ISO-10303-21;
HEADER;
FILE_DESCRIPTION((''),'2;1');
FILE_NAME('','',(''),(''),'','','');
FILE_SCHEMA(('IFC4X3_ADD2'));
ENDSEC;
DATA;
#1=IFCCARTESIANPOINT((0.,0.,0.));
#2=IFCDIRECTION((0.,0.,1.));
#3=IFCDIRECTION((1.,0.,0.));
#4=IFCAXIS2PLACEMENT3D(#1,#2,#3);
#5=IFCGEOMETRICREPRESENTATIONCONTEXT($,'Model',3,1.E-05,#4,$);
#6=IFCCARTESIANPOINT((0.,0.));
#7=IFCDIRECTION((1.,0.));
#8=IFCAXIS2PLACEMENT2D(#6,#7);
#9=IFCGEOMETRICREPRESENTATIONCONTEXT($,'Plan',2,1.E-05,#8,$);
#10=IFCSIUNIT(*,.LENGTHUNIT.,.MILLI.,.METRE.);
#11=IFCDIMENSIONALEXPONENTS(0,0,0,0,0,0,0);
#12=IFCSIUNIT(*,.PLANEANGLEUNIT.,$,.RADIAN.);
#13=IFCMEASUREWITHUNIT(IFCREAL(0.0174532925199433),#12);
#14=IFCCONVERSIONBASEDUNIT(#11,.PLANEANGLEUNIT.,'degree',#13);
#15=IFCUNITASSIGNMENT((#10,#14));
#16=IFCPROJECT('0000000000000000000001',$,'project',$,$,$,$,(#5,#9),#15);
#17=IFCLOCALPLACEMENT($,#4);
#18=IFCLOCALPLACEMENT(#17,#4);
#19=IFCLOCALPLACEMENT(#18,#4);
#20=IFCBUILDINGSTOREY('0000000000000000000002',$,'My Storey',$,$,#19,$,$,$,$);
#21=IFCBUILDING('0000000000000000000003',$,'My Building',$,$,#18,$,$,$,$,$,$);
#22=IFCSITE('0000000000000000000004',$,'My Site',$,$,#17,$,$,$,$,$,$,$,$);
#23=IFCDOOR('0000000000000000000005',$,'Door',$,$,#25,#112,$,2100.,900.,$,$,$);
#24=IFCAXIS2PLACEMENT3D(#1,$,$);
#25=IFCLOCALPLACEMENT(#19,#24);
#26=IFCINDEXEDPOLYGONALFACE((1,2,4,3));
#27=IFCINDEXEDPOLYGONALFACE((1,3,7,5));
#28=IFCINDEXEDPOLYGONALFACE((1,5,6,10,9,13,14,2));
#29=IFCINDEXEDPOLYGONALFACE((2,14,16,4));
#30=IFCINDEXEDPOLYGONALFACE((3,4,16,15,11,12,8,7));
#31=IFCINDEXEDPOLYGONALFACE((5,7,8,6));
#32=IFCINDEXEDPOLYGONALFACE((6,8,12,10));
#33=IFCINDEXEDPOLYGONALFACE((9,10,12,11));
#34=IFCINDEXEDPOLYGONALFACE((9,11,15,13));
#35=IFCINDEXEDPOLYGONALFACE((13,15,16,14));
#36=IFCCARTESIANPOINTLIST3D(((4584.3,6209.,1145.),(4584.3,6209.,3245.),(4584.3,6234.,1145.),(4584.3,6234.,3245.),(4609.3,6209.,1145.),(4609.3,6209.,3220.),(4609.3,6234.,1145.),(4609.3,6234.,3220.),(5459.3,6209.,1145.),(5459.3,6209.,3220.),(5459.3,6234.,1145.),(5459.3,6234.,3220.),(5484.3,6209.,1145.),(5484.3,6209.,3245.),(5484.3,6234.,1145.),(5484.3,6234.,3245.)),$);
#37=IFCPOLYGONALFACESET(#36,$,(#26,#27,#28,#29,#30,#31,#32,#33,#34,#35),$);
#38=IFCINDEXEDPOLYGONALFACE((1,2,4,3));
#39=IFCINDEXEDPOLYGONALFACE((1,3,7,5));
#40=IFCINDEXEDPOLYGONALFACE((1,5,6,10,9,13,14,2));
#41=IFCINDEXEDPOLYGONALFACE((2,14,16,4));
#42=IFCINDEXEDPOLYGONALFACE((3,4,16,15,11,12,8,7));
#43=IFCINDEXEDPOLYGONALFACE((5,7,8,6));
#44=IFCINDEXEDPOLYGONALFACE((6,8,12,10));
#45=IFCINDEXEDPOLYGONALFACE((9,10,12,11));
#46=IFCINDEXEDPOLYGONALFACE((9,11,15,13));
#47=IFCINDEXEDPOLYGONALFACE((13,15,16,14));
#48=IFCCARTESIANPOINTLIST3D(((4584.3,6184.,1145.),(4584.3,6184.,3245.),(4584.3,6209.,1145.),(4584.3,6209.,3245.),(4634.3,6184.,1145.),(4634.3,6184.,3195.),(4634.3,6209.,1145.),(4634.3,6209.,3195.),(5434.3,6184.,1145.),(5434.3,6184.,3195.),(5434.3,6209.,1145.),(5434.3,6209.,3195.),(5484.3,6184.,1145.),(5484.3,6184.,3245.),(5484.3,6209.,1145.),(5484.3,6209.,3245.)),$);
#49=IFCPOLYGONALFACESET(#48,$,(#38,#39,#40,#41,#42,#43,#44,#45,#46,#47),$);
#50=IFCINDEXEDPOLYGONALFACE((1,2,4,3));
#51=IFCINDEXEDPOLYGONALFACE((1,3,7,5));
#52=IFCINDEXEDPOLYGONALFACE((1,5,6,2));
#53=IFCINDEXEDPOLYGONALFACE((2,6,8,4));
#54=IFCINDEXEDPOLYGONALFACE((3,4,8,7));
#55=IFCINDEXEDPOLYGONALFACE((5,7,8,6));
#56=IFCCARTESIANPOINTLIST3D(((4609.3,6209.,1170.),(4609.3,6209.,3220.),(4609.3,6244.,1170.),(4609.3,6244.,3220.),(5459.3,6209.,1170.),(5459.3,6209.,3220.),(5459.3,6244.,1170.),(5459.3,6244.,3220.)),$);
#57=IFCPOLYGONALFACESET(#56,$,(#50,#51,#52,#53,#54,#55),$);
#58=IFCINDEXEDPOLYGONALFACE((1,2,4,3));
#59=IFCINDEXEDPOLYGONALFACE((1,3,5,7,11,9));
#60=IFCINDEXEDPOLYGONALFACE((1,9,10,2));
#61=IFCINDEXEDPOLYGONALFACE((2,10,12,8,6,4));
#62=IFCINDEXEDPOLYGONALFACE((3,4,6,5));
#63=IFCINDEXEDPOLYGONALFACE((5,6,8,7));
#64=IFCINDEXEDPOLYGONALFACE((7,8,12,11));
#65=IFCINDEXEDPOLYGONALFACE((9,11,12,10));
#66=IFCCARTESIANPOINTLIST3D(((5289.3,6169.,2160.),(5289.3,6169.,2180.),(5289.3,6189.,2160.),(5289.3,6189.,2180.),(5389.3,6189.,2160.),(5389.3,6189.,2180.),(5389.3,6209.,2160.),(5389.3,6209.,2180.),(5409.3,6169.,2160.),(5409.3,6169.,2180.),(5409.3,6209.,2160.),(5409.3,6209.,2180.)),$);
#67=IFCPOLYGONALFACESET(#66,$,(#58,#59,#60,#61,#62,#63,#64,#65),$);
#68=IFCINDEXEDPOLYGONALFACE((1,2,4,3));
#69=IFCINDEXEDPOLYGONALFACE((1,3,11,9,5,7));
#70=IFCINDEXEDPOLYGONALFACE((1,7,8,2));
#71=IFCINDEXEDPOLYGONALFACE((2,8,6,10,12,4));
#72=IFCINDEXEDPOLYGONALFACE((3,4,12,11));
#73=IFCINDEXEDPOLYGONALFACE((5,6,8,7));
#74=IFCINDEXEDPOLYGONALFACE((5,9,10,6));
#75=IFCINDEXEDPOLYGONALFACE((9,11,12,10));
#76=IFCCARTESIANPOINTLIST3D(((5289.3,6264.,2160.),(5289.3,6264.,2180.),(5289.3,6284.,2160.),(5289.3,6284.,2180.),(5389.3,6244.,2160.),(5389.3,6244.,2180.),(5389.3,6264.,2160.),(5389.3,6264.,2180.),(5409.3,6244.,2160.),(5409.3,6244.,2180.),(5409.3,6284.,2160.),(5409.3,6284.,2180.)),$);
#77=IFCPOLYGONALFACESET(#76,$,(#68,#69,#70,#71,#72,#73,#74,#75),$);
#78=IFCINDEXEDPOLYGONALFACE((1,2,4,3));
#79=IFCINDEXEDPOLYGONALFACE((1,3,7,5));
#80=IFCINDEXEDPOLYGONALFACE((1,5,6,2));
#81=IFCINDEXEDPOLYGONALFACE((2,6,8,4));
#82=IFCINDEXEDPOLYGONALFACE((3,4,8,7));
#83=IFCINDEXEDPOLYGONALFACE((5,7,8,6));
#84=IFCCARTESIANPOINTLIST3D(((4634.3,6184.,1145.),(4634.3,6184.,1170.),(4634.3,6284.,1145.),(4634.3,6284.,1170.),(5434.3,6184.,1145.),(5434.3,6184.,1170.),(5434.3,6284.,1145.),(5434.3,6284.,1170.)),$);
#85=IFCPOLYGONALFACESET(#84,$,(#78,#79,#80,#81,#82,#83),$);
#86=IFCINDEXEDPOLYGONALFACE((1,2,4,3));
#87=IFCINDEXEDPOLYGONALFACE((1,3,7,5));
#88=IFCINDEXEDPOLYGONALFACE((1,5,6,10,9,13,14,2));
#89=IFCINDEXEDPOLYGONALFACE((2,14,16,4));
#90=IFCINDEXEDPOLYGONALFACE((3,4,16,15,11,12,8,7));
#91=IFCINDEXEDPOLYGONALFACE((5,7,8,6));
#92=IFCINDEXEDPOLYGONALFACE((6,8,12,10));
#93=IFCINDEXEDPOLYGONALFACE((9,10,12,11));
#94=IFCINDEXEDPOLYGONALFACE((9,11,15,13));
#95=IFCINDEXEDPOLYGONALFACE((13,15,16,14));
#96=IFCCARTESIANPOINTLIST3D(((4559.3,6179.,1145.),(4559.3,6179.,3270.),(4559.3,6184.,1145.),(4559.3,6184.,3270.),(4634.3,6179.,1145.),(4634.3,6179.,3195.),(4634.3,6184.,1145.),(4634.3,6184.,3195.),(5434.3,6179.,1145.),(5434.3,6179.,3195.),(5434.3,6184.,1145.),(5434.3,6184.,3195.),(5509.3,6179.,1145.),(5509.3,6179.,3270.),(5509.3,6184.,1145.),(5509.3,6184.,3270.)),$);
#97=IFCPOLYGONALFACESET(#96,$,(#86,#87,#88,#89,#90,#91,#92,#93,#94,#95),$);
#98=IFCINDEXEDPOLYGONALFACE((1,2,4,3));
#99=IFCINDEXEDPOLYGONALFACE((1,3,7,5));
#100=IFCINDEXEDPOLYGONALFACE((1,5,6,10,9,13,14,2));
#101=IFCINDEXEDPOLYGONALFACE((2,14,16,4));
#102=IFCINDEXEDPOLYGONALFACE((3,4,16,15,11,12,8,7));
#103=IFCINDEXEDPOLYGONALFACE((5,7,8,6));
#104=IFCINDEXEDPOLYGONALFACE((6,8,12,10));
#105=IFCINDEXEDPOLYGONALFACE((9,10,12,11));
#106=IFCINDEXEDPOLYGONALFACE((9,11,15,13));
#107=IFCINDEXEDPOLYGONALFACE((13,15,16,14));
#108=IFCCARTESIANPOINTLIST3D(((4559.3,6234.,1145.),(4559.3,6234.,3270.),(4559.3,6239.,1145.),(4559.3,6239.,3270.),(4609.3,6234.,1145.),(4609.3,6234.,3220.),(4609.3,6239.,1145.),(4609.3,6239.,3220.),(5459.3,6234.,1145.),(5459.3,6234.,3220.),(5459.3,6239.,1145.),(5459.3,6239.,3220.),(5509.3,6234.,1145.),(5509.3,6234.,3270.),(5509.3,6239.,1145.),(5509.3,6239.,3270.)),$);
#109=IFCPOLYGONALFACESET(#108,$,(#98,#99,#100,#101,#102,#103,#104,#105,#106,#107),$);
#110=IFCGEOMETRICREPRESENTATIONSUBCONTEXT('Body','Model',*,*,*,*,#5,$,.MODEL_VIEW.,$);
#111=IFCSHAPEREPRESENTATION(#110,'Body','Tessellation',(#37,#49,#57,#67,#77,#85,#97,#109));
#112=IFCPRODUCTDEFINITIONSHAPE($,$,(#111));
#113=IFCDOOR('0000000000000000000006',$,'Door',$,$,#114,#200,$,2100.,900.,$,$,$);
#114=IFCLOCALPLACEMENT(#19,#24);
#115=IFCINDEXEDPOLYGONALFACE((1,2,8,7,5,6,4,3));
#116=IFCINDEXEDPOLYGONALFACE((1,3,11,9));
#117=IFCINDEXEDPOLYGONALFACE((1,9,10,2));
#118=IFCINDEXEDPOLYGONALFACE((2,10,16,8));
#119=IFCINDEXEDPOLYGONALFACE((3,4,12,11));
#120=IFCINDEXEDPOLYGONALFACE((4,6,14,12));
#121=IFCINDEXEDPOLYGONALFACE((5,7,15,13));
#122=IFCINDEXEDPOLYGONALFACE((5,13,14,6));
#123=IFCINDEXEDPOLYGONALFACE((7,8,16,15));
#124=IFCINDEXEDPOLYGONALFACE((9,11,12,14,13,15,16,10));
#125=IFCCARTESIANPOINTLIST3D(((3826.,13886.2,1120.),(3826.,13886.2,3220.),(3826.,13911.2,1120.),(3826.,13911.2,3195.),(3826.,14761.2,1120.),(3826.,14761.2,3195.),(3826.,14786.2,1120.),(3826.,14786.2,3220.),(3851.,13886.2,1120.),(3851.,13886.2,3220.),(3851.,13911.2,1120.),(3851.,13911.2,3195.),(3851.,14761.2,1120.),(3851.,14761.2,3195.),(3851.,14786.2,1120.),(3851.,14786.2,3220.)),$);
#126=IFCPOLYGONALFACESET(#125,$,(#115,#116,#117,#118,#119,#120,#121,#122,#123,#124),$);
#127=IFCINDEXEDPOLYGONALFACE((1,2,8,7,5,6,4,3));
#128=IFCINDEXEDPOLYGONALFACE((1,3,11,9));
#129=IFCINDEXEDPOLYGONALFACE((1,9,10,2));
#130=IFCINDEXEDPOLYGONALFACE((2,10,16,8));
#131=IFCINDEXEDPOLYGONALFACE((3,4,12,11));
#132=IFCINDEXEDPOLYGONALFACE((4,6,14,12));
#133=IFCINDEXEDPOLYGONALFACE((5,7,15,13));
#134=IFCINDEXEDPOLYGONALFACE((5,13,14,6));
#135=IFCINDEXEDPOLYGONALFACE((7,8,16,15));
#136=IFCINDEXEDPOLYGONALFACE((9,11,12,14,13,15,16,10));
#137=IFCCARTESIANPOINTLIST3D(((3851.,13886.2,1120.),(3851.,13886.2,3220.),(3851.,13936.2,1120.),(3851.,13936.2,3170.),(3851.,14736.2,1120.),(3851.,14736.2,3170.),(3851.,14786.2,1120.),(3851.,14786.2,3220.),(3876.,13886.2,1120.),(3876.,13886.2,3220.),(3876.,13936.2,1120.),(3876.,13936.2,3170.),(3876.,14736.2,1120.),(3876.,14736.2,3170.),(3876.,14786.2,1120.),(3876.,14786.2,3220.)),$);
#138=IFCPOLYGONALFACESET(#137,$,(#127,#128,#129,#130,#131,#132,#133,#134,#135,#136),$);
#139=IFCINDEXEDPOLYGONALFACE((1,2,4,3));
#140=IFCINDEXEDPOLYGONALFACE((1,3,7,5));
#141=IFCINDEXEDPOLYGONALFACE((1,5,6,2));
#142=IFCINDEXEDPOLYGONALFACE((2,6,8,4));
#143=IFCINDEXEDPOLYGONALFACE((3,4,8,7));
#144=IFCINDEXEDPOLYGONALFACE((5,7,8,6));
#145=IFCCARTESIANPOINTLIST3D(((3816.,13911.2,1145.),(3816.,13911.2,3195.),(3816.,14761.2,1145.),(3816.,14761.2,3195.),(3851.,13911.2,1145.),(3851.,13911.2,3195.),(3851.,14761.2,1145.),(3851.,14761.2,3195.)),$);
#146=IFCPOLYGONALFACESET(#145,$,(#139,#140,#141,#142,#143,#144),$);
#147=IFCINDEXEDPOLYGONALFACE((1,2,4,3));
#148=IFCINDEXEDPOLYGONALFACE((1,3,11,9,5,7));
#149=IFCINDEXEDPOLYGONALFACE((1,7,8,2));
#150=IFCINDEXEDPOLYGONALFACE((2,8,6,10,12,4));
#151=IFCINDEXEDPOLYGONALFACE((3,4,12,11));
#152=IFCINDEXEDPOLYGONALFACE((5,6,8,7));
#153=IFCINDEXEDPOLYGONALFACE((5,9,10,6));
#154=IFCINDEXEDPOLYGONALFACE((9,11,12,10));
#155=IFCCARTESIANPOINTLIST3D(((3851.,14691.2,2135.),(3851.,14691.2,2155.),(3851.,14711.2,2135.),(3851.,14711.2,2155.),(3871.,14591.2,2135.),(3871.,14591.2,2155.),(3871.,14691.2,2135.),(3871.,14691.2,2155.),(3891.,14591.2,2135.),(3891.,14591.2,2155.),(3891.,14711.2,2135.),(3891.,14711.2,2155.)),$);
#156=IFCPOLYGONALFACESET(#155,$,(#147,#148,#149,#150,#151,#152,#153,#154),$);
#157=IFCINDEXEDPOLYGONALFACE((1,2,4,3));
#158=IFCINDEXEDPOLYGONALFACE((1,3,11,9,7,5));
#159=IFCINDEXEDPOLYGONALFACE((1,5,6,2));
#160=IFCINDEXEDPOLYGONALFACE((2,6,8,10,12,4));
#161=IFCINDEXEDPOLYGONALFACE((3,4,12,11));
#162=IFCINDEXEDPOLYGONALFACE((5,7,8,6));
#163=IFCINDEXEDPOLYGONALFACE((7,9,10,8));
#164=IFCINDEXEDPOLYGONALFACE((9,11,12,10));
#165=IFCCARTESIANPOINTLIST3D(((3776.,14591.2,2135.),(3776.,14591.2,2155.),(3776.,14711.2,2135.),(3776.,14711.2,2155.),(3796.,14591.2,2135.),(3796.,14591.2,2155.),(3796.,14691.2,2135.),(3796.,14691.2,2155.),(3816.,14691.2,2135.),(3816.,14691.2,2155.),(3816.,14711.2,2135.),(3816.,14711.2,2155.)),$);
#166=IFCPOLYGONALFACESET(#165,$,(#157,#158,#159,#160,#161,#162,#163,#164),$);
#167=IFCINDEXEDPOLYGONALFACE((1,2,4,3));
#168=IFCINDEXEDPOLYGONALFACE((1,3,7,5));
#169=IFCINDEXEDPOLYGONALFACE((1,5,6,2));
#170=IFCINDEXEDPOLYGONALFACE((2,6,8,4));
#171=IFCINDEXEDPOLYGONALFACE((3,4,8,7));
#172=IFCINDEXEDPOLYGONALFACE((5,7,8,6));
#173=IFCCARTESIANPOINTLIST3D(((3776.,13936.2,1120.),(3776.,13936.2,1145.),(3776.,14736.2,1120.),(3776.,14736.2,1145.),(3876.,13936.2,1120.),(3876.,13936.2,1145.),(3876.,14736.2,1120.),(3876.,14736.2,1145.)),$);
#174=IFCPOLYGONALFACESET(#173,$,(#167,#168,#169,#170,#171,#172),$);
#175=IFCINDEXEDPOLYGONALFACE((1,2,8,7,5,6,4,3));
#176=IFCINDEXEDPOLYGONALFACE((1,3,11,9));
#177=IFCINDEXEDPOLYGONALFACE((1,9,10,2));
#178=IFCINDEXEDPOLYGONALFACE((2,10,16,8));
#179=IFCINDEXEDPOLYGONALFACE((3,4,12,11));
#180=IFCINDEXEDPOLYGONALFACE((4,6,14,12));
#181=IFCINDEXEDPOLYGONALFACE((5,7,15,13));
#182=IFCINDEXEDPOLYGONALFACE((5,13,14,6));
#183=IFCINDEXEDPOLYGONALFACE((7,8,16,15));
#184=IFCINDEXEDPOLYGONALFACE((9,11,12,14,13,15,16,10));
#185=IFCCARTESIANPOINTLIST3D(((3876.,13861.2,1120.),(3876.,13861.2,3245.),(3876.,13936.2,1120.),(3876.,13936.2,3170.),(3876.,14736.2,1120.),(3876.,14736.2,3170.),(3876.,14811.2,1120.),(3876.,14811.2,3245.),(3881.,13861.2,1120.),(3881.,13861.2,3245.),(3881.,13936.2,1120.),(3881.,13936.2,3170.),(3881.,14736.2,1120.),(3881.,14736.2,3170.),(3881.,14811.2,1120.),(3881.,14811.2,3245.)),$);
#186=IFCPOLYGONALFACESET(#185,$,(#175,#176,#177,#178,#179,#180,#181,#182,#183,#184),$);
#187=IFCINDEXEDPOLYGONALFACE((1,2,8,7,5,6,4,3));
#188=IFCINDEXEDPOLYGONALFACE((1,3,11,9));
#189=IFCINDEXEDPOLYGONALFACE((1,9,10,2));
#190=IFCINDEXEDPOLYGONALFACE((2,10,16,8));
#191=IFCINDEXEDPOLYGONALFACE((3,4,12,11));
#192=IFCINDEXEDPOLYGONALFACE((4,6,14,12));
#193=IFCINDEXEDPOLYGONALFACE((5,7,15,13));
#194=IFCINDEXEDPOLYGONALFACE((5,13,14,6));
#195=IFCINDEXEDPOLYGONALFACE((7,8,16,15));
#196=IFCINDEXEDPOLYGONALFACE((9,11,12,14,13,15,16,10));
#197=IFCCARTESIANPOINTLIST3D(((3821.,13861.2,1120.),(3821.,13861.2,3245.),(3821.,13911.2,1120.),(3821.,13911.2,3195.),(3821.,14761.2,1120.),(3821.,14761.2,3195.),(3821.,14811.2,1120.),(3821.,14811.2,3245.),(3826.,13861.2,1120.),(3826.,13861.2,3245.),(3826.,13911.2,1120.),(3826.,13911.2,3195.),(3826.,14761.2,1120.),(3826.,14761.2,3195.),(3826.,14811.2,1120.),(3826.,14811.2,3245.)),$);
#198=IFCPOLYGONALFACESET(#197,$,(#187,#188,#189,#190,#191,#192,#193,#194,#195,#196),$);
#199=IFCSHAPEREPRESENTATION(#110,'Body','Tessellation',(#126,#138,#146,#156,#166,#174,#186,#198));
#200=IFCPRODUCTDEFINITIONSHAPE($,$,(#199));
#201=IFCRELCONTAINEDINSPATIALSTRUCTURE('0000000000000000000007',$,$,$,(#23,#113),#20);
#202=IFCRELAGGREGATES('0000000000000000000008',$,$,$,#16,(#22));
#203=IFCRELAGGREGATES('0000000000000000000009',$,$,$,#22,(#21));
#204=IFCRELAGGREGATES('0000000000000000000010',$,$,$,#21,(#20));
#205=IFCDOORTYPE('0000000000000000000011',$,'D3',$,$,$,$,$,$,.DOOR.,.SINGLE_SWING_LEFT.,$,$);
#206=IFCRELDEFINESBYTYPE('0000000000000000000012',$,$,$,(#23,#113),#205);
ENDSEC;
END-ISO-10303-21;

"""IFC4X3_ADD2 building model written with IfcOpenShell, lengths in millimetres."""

from ifc_helpers import new_model, entity, si_unit, converted_unit, frame, origin_with_axes, origin_2d_with_axis, place, context, subcontext, project, spatial, line, indexed_curve, outline, extrude, shape, source, transform, mapped, type_object, type_shapes, element, save


model = new_model("IFC4X3_ADD2")

# Units and contexts
model_context = context("Model", 3, precision=1e-05, world=origin_with_axes())
plan_context = context("Plan", 2, precision=1e-05, world=origin_2d_with_axis())
body_context_1 = subcontext(model_context, "Body", "Model", "MODEL_VIEW")
body_context_2 = subcontext(plan_context, "Body", "Plan", "PLAN_VIEW")
ifc_project = project(units=[si_unit("LENGTHUNIT", "METRE", prefix="MILLI"), converted_unit("PLANEANGLEUNIT", "degree", entity("IfcReal", 0.0174532925199433), si_unit("PLANEANGLEUNIT", "RADIAN"), dimensions=[0, 0, 0, 0, 0, 0, 0])], contexts=[model_context, plan_context])

# Site, building, storey
site_placement = place(None, origin_with_axes())
site = spatial("IfcSite", under=ifc_project, at=site_placement, Name="My Site")
building_placement = place(site_placement, origin_with_axes())
building = spatial("IfcBuilding", under=site, at=building_placement, Name="My Building")
storey_placement = place(building_placement, origin_with_axes())
storey = spatial("IfcBuildingStorey", under=building, at=storey_placement, Name="My Storey")

# Doors
door_type = type_object("IfcDoorType", Name="D3", OperationType="SINGLE_SWING_LEFT", PredefinedType="DOOR")
shared_shape_1 = source(origin_with_axes(), body_context_1, "Body", "SweptSolid", [
    extrude(outline(indexed_curve([(0.0, 0.0), (0.0, 2100.0), (900.0, 2100.0), (900.0, 0.0), (875.0, 0.0), (875.0, 2075.0), (25.0, 2075.0), (25.0, 0.0)], segments=[line(1, 2, 3, 4, 5, 6, 7, 8, 1)])), frame((0.0, 25.0, 0.0), z_axis=(0.0, -1.0, 0.0), x_axis=(1.0, 0.0, 0.0)), (0.0, 0.0, -1.0), 25.0),
    extrude(outline(indexed_curve([(0.0, 0.0), (0.0, 2100.0), (900.0, 2100.0), (900.0, 0.0), (850.0, 0.0), (850.0, 2050.0), (50.0, 2050.0), (50.0, 0.0)], segments=[line(1, 2, 3, 4, 5, 6, 7, 8, 1)])), frame((0.0, 0.0, 0.0), z_axis=(0.0, -1.0, 0.0), x_axis=(1.0, 0.0, 0.0)), (0.0, 0.0, -1.0), 25.0),
    extrude(outline(indexed_curve([(0.0, 0.0), (850.0, 0.0), (850.0, 35.0), (0.0, 35.0)], segments=[line(1, 2, 3, 4, 1)])), frame((25.0, 25.0, 25.0), z_axis=(0.0, 0.0, 1.0), x_axis=(1.0, 0.0, 0.0)), (0.0, 0.0, 1.0), 2050.0),
    extrude(outline(indexed_curve([(0.0, 0.0), (0.0, -40.0), (-120.0, -40.0), (-120.0, -20.0), (-20.0, -20.0), (-20.0, 0.0)], segments=[line(1, 2, 3, 4, 5, 6, 1)])), frame((825.0, 25.0, 1015.0), z_axis=(0.0, 0.0, 1.0), x_axis=(1.0, 0.0, 0.0)), (0.0, 0.0, 1.0), 20.0),
    extrude(outline(indexed_curve([(0.0, 0.0), (0.0, 40.0), (-120.0, 40.0), (-120.0, 20.0), (-20.0, 20.0), (-20.0, 0.0)], segments=[line(1, 2, 3, 4, 5, 6, 1)])), frame((825.0, 60.0, 1015.0), z_axis=(0.0, 0.0, 1.0), x_axis=(1.0, 0.0, 0.0)), (0.0, 0.0, 1.0), 20.0),
    extrude(outline(indexed_curve([(0.0, 0.0), (800.0, 0.0), (800.0, 100.0), (0.0, 100.0)], segments=[line(1, 2, 3, 4, 1)])), frame((50.0, 0.0, 0.0), z_axis=(0.0, 0.0, 1.0), x_axis=(1.0, 0.0, 0.0)), (0.0, 0.0, 1.0), 25.0),
    extrude(outline(indexed_curve([(0.0, 0.0), (0.0, 2125.0), (950.0, 2125.0), (950.0, 0.0), (875.0, 0.0), (875.0, 2050.0), (75.0, 2050.0), (75.0, 0.0)], segments=[line(1, 2, 3, 4, 5, 6, 7, 8, 1)])), frame((-25.0, -5.0, 0.0), z_axis=(0.0, -1.0, 0.0), x_axis=(1.0, 0.0, 0.0)), (0.0, 0.0, -1.0), 5.0),
    extrude(outline(indexed_curve([(0.0, 0.0), (0.0, 2125.0), (950.0, 2125.0), (950.0, 0.0), (900.0, 0.0), (900.0, 2075.0), (50.0, 2075.0), (50.0, 0.0)], segments=[line(1, 2, 3, 4, 5, 6, 7, 8, 1)])), frame((-25.0, 50.0, 0.0), z_axis=(0.0, -1.0, 0.0), x_axis=(1.0, 0.0, 0.0)), (0.0, 0.0, -1.0), 5.0),
])
shared_shape_2 = source(origin_with_axes(), body_context_2, "Body", "Curve2D", [
    entity("IfcIndexedPolyCurve", entity("IfcCartesianPointList2D", [[0.0, 0.0], [0.0, 50.0], [25.0, 50.0], [25.0, 25.0], [50.0, 25.0], [50.0, 0.0]]), [entity("IfcLineIndex", [1, 2, 3, 4, 5, 6, 1])]),
    entity("IfcIndexedPolyCurve", entity("IfcCartesianPointList2D", [[900.0, 0.0], [900.0, 50.0], [875.0, 50.0], [875.0, 25.0], [850.0, 25.0], [850.0, 0.0]]), [entity("IfcLineIndex", [1, 2, 3, 4, 5, 6, 1])]),
    entity("IfcTrimmedCurve", entity("IfcEllipse", entity("IfcAxis2Placement2D", entity("IfcCartesianPoint", [60.0, 50.0]), entity("IfcDirection", [1.0, 0.0])), 815.0, 850.0), [entity("IfcCartesianPoint", [875.0, 50.0])], [entity("IfcCartesianPoint", [60.0, 900.0])], True, "CARTESIAN"),
    entity("IfcIndexedPolyCurve", entity("IfcCartesianPointList2D", [[25.0, 50.0], [60.0, 50.0], [60.0, 900.0], [25.0, 900.0]]), [entity("IfcLineIndex", [1, 2, 3, 4, 1])]),
])
type_shapes(door_type, [shared_shape_1, shared_shape_2])
for number, where, z_axis, x_axis, name in (
    (1, (4584.3, 6184.0, 1145.0), (0.0, 0.0, 1.0), (1.0, 0.0, 0.0), "Door"),
    (2, (3876.0, 13886.2, 1120.0), (0.0, 0.0, 1.0), (0.0, 1.0, 0.0), "Door"),
):
    element("IfcDoor", number, at=place(storey_placement, frame(where, z_axis=z_axis, x_axis=x_axis)), inside=storey, type_object=door_type, Name=name, OverallHeight=2100.0, OverallWidth=900.0, shapes=[
        shape(body_context_1, "Body", "MappedRepresentation", [mapped(shared_shape_1, transform((0.0, 0.0, 0.0), x_axis=(1.0, 0.0, 0.0), y_axis=(0.0, 1.0, 0.0), z_axis=(0.0, 0.0, 1.0), scale=1.0))]),
        shape(body_context_2, "Body", "MappedRepresentation", [mapped(shared_shape_2, transform((0.0, 0.0, 0.0), x_axis=(1.0, 0.0, 0.0), y_axis=(0.0, 1.0, 0.0), z_axis=(0.0, 0.0, 1.0), scale=1.0))]),
    ])

save(model, "model.ifc")
